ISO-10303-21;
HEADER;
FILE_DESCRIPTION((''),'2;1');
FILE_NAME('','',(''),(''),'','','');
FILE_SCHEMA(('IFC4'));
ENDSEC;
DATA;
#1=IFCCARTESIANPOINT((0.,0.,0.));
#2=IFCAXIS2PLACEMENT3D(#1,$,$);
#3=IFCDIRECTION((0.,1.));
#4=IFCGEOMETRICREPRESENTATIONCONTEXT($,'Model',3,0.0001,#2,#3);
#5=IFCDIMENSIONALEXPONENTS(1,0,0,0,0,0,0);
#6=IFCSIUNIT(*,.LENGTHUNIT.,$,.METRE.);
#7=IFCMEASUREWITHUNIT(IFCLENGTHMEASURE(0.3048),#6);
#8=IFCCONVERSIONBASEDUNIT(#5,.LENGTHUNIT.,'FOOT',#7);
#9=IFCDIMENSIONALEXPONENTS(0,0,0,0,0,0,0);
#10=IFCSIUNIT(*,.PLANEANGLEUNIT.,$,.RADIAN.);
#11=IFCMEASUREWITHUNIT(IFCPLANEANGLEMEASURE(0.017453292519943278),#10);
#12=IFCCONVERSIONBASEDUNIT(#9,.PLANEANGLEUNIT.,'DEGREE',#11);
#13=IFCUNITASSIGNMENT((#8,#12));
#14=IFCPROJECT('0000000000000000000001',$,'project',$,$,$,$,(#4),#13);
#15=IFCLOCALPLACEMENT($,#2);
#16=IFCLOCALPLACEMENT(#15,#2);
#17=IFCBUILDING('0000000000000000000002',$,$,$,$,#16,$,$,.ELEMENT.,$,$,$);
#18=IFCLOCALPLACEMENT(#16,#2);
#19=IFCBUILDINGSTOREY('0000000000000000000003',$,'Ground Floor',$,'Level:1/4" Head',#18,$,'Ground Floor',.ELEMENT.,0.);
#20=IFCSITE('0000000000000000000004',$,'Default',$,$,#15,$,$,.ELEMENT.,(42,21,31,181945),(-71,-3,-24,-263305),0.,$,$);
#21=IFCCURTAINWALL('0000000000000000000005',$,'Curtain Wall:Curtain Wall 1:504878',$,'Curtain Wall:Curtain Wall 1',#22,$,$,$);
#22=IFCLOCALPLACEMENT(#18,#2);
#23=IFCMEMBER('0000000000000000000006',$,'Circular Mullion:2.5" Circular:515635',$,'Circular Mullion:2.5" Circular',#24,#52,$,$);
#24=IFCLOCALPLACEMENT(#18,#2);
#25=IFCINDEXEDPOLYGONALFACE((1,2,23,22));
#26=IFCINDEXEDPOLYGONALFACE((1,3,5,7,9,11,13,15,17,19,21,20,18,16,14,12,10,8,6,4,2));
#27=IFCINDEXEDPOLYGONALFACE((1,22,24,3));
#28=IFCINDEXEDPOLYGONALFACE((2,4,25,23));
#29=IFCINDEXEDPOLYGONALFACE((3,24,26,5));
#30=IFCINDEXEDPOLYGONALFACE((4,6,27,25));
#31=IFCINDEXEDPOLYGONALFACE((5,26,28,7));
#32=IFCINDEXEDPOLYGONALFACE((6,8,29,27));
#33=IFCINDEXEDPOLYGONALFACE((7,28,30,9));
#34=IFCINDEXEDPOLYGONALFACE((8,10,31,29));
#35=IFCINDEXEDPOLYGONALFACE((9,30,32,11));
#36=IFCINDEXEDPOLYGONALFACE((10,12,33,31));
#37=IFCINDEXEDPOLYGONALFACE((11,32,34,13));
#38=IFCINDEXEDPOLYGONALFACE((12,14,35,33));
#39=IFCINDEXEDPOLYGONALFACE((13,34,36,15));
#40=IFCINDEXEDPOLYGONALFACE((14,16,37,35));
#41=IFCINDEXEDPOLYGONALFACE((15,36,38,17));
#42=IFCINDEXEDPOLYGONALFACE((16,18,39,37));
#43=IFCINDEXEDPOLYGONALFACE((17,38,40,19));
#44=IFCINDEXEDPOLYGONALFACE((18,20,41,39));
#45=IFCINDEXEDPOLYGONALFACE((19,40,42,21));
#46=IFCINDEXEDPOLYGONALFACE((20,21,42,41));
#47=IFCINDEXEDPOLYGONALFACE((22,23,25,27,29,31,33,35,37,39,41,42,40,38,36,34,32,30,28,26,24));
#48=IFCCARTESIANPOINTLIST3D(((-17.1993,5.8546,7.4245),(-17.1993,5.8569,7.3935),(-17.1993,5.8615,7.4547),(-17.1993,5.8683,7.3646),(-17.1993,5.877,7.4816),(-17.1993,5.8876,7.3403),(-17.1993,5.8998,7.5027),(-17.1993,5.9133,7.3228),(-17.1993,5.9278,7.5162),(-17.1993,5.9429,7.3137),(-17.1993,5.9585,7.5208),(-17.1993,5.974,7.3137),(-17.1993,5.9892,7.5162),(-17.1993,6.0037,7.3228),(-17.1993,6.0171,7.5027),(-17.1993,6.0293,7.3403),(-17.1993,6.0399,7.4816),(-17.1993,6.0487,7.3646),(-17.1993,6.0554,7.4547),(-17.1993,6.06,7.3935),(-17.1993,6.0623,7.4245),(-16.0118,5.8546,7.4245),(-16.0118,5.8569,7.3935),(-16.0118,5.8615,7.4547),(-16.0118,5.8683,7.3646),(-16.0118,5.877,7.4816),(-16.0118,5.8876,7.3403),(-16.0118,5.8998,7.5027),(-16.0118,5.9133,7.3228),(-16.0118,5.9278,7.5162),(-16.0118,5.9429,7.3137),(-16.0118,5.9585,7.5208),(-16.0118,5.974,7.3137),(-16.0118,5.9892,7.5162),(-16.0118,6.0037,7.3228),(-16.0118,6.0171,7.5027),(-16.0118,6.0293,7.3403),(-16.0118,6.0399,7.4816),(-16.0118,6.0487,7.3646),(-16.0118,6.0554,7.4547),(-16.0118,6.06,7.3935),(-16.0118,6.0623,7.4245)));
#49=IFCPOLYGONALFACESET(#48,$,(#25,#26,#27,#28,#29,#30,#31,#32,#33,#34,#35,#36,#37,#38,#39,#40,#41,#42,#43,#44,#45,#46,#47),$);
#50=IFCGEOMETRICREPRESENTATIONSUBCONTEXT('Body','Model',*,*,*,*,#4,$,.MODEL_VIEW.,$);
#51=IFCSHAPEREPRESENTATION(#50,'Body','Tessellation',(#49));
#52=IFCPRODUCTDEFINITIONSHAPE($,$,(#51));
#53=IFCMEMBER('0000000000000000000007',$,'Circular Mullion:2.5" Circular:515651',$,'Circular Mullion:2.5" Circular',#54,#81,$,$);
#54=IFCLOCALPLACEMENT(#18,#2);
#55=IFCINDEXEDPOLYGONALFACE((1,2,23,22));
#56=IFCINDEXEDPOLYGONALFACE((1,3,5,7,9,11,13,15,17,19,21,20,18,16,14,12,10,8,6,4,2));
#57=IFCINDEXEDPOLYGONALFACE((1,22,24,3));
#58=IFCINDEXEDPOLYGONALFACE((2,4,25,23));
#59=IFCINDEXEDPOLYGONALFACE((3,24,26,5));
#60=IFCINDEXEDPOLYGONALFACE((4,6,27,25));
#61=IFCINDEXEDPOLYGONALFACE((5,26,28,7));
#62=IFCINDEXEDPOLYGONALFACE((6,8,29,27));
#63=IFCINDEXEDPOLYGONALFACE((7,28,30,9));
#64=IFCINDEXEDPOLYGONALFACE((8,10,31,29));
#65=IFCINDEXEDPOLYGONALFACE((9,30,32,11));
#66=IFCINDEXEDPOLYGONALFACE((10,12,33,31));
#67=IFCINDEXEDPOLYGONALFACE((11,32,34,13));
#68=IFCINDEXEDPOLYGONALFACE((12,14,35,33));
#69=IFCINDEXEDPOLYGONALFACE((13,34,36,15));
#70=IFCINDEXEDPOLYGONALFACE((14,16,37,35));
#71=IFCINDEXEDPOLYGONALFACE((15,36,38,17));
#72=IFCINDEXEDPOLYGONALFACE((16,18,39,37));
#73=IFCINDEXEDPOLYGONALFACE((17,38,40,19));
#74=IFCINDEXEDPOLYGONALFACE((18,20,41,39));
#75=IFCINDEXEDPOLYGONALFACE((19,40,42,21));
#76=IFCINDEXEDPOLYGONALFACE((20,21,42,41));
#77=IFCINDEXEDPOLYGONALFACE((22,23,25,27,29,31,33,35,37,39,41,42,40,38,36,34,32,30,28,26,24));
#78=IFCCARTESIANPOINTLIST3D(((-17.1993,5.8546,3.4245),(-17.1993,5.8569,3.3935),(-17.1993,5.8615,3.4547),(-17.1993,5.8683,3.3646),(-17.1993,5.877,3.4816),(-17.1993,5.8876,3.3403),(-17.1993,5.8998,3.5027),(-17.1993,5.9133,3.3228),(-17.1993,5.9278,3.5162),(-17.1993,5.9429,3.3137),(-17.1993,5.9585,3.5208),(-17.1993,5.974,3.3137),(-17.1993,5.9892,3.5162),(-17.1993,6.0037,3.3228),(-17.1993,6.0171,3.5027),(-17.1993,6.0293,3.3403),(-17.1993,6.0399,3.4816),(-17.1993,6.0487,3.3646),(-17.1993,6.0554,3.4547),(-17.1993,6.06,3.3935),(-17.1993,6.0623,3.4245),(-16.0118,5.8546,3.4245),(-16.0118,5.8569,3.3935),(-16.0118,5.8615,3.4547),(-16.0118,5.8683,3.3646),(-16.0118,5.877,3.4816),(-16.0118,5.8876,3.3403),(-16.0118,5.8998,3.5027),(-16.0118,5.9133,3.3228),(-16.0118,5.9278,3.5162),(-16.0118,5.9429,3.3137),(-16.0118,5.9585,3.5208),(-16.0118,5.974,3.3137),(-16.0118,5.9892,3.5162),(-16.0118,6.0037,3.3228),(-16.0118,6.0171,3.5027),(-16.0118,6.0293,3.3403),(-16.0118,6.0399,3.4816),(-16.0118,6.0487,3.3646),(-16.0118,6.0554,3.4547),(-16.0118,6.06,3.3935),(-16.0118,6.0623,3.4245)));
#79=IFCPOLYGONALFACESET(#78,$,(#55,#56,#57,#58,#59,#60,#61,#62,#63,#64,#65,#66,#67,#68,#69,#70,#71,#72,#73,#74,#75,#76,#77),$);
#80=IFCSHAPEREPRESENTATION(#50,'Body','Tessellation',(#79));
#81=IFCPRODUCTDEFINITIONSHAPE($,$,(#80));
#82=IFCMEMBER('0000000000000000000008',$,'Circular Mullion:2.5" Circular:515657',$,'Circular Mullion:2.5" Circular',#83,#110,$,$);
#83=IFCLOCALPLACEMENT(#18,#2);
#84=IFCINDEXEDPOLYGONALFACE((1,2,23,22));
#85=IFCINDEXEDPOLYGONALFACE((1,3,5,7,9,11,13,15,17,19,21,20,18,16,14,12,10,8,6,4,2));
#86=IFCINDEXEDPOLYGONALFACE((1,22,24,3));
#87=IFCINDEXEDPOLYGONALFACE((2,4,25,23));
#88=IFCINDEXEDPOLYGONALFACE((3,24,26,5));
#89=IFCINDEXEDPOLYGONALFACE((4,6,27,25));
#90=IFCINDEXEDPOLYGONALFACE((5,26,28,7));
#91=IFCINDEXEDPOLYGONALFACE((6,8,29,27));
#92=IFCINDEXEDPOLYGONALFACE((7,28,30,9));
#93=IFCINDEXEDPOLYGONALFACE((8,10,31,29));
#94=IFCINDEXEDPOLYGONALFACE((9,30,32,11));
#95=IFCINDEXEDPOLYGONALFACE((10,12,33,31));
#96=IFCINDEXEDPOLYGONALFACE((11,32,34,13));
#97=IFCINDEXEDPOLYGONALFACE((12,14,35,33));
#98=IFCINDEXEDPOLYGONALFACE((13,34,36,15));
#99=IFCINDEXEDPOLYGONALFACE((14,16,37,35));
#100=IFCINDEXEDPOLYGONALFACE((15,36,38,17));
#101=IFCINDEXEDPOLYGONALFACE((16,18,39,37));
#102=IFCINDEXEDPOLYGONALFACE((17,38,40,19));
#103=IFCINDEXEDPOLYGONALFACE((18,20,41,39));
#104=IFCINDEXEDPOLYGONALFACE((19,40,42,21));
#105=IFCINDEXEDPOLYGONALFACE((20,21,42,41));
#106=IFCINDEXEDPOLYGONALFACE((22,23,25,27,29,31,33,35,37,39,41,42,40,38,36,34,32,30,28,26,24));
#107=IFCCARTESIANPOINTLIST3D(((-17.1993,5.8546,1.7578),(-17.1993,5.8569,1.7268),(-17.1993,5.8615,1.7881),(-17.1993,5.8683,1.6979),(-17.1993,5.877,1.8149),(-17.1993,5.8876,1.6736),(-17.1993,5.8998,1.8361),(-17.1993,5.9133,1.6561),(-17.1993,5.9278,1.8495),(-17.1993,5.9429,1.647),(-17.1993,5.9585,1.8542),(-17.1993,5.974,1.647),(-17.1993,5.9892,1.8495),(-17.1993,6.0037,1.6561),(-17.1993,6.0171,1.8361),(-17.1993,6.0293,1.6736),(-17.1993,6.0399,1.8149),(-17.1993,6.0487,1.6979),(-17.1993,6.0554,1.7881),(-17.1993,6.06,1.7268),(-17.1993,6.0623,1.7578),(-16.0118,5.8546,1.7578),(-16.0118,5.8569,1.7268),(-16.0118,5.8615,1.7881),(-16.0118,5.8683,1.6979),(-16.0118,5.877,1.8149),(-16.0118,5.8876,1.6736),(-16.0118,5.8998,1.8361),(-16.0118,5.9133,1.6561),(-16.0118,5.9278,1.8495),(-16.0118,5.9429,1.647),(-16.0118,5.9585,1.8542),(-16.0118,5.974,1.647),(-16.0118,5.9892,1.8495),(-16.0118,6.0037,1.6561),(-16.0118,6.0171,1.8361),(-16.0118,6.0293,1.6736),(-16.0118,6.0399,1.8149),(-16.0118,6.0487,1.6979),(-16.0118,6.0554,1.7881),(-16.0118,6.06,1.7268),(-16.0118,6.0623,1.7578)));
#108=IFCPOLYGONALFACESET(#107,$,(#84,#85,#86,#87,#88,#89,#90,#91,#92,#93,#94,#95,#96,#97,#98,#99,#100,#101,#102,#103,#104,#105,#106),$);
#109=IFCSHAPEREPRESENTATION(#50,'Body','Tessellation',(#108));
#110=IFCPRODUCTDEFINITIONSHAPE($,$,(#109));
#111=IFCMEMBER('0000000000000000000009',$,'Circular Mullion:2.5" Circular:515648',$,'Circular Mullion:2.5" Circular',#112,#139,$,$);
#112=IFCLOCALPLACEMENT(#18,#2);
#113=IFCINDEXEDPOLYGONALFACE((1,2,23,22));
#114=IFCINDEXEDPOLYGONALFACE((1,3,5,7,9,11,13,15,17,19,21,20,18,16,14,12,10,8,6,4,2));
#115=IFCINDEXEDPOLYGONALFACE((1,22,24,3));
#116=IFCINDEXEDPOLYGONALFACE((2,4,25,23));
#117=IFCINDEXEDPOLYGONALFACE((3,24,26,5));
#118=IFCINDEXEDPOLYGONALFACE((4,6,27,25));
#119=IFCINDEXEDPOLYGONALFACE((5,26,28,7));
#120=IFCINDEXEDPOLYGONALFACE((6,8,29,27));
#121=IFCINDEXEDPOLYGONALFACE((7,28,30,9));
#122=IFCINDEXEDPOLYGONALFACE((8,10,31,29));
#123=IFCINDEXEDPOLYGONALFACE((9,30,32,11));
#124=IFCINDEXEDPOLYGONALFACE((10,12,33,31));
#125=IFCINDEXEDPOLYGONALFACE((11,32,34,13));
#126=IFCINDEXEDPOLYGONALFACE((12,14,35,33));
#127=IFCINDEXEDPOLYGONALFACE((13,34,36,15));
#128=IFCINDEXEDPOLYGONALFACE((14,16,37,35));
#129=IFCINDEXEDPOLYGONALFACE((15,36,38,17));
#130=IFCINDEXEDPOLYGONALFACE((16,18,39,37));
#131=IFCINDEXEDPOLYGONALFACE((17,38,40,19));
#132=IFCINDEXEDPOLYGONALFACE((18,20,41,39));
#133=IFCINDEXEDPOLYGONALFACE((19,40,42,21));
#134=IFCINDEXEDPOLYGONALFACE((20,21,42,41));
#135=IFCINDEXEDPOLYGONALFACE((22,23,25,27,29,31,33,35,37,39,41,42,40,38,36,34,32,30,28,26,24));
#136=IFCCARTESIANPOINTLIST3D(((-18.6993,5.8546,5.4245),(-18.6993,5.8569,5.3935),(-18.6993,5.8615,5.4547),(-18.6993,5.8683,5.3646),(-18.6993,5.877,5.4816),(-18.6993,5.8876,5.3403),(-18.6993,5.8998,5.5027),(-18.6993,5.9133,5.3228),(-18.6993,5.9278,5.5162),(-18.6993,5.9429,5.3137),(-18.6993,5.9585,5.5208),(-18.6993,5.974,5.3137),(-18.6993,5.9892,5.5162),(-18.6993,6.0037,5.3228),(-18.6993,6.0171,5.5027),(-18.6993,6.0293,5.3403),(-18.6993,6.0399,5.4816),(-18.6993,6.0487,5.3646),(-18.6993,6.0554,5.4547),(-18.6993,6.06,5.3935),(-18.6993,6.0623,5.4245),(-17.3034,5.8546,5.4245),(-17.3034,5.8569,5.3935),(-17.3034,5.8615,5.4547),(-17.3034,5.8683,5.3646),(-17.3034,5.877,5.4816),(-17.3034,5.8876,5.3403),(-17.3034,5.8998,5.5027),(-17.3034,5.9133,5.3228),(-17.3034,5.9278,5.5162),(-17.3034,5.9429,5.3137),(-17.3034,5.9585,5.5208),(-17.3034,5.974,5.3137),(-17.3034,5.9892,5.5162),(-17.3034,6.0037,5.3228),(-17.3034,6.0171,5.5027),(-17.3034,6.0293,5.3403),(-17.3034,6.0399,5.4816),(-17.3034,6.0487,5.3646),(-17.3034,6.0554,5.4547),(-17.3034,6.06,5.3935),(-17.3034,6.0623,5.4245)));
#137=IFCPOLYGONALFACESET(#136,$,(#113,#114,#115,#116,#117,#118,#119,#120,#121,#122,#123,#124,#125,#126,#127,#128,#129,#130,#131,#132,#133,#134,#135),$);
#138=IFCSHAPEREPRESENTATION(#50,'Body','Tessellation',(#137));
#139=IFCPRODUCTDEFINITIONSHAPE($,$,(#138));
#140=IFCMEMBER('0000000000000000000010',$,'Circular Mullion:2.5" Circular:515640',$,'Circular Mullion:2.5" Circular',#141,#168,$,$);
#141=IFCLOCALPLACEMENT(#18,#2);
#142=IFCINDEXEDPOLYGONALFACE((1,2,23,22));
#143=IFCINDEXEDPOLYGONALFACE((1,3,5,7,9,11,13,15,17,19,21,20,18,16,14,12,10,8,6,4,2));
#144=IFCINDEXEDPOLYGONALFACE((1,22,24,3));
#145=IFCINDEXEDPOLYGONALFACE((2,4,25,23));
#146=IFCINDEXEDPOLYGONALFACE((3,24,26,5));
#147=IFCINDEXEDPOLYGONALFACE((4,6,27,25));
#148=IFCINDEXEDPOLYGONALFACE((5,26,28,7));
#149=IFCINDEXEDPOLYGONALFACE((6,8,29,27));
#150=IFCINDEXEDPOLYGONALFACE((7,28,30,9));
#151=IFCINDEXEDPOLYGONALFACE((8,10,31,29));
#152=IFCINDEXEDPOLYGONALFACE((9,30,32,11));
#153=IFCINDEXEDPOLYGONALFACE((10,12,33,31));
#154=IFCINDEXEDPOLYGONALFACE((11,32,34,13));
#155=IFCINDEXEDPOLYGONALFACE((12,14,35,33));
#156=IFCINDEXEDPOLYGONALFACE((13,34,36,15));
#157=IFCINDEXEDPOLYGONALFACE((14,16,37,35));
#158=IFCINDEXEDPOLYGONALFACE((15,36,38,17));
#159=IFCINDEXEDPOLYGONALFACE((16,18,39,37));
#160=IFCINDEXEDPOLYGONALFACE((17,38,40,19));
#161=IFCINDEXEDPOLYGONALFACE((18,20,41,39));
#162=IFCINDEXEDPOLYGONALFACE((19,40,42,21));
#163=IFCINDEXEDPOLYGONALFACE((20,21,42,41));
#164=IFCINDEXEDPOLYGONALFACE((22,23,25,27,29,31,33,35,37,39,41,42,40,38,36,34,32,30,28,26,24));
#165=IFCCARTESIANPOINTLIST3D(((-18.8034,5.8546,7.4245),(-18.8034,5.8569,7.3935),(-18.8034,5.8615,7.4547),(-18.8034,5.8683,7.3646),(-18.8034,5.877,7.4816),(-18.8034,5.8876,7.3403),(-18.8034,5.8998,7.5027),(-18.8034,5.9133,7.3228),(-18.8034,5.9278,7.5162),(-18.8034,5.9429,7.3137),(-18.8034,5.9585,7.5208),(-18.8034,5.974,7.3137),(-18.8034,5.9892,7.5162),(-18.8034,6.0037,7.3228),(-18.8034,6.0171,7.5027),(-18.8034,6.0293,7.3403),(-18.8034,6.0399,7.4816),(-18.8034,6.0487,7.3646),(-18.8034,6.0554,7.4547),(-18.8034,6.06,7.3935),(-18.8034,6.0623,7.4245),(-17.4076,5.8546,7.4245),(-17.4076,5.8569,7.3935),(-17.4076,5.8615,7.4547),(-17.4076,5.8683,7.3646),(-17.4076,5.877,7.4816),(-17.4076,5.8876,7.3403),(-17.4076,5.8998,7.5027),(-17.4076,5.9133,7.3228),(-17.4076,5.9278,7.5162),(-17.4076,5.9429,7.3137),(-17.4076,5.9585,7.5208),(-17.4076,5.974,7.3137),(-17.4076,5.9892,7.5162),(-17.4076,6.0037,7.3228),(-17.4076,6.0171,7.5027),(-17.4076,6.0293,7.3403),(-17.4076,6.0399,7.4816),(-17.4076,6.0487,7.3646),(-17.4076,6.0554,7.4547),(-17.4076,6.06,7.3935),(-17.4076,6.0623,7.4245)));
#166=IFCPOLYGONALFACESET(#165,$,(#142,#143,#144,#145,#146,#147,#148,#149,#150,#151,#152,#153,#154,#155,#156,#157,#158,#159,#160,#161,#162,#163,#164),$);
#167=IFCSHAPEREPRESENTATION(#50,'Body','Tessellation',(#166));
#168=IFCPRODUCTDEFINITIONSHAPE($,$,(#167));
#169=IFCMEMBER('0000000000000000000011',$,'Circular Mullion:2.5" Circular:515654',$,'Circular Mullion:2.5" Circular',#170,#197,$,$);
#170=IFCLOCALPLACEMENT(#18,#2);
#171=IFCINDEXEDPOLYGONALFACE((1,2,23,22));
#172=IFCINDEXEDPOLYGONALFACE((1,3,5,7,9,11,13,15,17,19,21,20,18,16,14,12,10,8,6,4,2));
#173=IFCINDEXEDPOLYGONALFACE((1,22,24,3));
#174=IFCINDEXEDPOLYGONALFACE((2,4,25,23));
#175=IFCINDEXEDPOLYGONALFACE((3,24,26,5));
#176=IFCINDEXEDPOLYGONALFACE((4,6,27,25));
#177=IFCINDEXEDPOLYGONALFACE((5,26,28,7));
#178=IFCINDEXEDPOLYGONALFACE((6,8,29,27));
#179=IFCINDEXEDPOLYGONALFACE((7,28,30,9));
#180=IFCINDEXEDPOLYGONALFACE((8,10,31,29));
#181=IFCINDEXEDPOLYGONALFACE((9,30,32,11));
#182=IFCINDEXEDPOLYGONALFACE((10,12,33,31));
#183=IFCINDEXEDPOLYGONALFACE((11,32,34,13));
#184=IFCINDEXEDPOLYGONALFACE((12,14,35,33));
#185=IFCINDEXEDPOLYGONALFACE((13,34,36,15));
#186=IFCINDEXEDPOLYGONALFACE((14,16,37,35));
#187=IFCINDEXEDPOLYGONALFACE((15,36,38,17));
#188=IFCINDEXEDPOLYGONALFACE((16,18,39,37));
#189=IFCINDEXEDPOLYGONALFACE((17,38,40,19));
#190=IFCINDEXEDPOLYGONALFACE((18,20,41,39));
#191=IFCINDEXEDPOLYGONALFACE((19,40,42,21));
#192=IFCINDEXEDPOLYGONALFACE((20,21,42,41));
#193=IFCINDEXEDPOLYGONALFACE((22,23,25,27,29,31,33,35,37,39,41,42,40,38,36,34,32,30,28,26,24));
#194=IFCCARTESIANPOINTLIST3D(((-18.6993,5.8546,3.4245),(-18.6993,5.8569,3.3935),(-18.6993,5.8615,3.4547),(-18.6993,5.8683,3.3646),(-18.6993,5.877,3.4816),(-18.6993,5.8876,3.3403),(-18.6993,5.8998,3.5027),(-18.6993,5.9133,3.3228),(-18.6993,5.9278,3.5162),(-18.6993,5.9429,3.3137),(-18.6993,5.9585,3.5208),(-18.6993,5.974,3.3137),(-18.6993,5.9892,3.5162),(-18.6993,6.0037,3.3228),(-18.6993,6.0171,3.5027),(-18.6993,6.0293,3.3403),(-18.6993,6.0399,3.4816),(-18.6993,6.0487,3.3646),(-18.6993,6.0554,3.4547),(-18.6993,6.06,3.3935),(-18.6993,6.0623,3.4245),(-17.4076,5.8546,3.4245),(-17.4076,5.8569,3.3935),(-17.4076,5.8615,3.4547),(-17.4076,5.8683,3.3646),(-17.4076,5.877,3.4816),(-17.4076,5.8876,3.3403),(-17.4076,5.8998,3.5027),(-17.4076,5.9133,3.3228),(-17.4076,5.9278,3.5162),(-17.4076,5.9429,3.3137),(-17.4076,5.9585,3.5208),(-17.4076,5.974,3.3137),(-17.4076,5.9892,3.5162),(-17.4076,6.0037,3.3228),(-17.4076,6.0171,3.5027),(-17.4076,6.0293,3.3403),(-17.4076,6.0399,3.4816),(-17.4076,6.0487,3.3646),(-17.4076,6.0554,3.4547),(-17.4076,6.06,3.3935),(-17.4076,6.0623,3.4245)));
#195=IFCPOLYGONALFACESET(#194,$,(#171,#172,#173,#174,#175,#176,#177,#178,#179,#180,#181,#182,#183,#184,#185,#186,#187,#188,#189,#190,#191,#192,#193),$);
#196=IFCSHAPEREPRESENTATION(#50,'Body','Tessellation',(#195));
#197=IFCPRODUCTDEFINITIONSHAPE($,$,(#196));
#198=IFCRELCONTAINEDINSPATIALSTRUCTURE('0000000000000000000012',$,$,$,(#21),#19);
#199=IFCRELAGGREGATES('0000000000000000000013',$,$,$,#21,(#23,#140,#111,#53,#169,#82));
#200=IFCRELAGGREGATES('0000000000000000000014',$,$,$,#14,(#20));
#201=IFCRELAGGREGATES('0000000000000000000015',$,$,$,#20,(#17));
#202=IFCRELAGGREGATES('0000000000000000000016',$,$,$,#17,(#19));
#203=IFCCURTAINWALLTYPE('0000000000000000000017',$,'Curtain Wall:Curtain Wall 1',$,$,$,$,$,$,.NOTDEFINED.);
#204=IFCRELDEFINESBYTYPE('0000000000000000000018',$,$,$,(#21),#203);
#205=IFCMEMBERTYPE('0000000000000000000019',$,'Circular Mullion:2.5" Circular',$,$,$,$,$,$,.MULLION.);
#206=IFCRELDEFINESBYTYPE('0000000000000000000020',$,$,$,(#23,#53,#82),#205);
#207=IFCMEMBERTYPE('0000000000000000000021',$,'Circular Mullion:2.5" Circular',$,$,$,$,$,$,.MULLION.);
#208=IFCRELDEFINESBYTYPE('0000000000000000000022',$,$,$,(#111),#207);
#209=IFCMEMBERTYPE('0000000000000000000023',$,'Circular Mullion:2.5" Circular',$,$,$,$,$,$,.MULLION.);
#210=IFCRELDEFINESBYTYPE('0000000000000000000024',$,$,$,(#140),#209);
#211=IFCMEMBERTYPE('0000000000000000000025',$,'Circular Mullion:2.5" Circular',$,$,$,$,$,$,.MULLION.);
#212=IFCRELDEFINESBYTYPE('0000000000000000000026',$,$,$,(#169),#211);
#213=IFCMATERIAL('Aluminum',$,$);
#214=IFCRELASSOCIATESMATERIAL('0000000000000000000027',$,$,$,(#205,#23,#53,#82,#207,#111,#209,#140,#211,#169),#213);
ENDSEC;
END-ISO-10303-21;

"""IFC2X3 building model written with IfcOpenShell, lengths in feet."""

from ifc_helpers import new_model, entity, si_unit, converted_unit, direction, frame, frame_2d, origin, place, context, subcontext, project, spatial, circle, extrude, source, transform, mapped, material, type_object, type_shapes, element, aggregate, save


model = new_model("IFC2X3")

# Units and contexts
model_context = context("Model", 3, precision=0.0001, world=origin(), true_north=direction((0.0, 1.0)))
body_context = subcontext(model_context, "Body", "Model", "MODEL_VIEW")
ifc_project = project(units=[converted_unit("LENGTHUNIT", "FOOT", entity("IfcLengthMeasure", 0.3048), si_unit("LENGTHUNIT", "METRE"), dimensions=[1, 0, 0, 0, 0, 0, 0]), converted_unit("PLANEANGLEUNIT", "DEGREE", entity("IfcPlaneAngleMeasure", 0.017453292519943278), si_unit("PLANEANGLEUNIT", "RADIAN"), dimensions=[0, 0, 0, 0, 0, 0, 0])], contexts=[model_context])

# Site, building, storey
site_placement = place(None, origin())
site = spatial("IfcSite", under=ifc_project, at=site_placement, Name="Default", CompositionType="ELEMENT", RefLatitude=(42, 21, 31, 181945), RefLongitude=(-71, -3, -24, -263305), RefElevation=0.0)
building_placement = place(site_placement, origin())
building = spatial("IfcBuilding", under=site, at=building_placement, CompositionType="ELEMENT")
storey_placement = place(building_placement, origin())
storey = spatial("IfcBuildingStorey", under=building, at=storey_placement, Name="Ground Floor", ObjectType="Level:1/4\" Head", LongName="Ground Floor", CompositionType="ELEMENT", Elevation=0.0)

# Curtain wall, members
curtain_wall_type = type_object("IfcCurtainWallType", Name="Curtain Wall:Curtain Wall 1", PredefinedType="NOTDEFINED")
curtain_wall_placement = place(storey_placement, origin())
curtain_wall = element("IfcCurtainWall", 1, at=curtain_wall_placement, inside=storey, type_object=curtain_wall_type, Name="Curtain Wall:Curtain Wall 1:504878", ObjectType="Curtain Wall:Curtain Wall 1")
ifc_material_1 = material(Name="Aluminum")
member_type_1 = type_object("IfcMemberType", Name="Circular Mullion:2.5\" Circular", PredefinedType="MULLION", material=ifc_material_1)
shared_shape_1 = source(origin(), body_context, "Body", "SweptSolid", [
    extrude(circle(Radius=0.1042, at=frame_2d((0.0, 0.0), x_axis=(1.0, 0.0))), frame((0.0, 0.0, -1.1875)), (0.0, 0.0, 1.0), 1.1875),
])
type_shapes(member_type_1, [shared_shape_1])
member_1_placement = place(curtain_wall_placement, frame((-17.1993, 5.9585, 7.4167), z_axis=(-1.0, 0.0, 0.0), x_axis=(0.0, 0.0, 1.0)))
member_1 = element("IfcMember", 2, at=member_1_placement, type_object=member_type_1, material=ifc_material_1, Name="Circular Mullion:2.5\" Circular:515635", ObjectType="Circular Mullion:2.5\" Circular", context=body_context, shape_type="MappedRepresentation", body=[
    mapped(shared_shape_1, transform((0.0, 0.0, 0.0), scale=1.0)),
])
member_2_placement = place(curtain_wall_placement, frame((-17.1993, 5.9585, 3.4167), z_axis=(-1.0, 0.0, 0.0), x_axis=(0.0, 0.0, 1.0)))
member_2 = element("IfcMember", 3, at=member_2_placement, type_object=member_type_1, material=ifc_material_1, Name="Circular Mullion:2.5\" Circular:515651", ObjectType="Circular Mullion:2.5\" Circular", context=body_context, shape_type="MappedRepresentation", body=[
    mapped(shared_shape_1, transform((0.0, 0.0, 0.0), scale=1.0)),
])
member_3_placement = place(curtain_wall_placement, frame((-17.1993, 5.9585, 1.75), z_axis=(-1.0, 0.0, 0.0), x_axis=(0.0, 0.0, 1.0)))
member_3 = element("IfcMember", 4, at=member_3_placement, type_object=member_type_1, material=ifc_material_1, Name="Circular Mullion:2.5\" Circular:515657", ObjectType="Circular Mullion:2.5\" Circular", context=body_context, shape_type="MappedRepresentation", body=[
    mapped(shared_shape_1, transform((0.0, 0.0, 0.0), scale=1.0)),
])
member_type_2 = type_object("IfcMemberType", Name="Circular Mullion:2.5\" Circular", PredefinedType="MULLION", material=ifc_material_1)
shared_shape_2 = source(origin(), body_context, "Body", "SweptSolid", [
    extrude(circle(Radius=0.1042, at=frame_2d((0.0, 0.0), x_axis=(1.0, 0.0))), frame((0.0, 0.0, -1.3958)), (0.0, 0.0, 1.0), 1.3958),
])
type_shapes(member_type_2, [shared_shape_2])
member_4_placement = place(curtain_wall_placement, frame((-18.6993, 5.9585, 5.4167), z_axis=(-1.0, 0.0, 0.0), x_axis=(0.0, 0.0, 1.0)))
member_4 = element("IfcMember", 5, at=member_4_placement, type_object=member_type_2, material=ifc_material_1, Name="Circular Mullion:2.5\" Circular:515648", ObjectType="Circular Mullion:2.5\" Circular", context=body_context, shape_type="MappedRepresentation", body=[
    mapped(shared_shape_2, transform((0.0, 0.0, 0.0), scale=1.0)),
])
member_type_3 = type_object("IfcMemberType", Name="Circular Mullion:2.5\" Circular", PredefinedType="MULLION", material=ifc_material_1)
shared_shape_3 = source(origin(), body_context, "Body", "SweptSolid", [
    extrude(circle(Radius=0.1042, at=frame_2d((0.0, 0.0), x_axis=(1.0, 0.0))), frame((0.0, 0.0, -1.3958)), (0.0, 0.0, 1.0), 1.3958),
])
type_shapes(member_type_3, [shared_shape_3])
member_5_placement = place(curtain_wall_placement, frame((-18.8034, 5.9585, 7.4167), z_axis=(-1.0, 0.0, 0.0), x_axis=(0.0, 0.0, 1.0)))
member_5 = element("IfcMember", 6, at=member_5_placement, type_object=member_type_3, material=ifc_material_1, Name="Circular Mullion:2.5\" Circular:515640", ObjectType="Circular Mullion:2.5\" Circular", context=body_context, shape_type="MappedRepresentation", body=[
    mapped(shared_shape_3, transform((0.0, 0.0, 0.0), scale=1.0)),
])
member_type_4 = type_object("IfcMemberType", Name="Circular Mullion:2.5\" Circular", PredefinedType="MULLION", material=ifc_material_1)
shared_shape_4 = source(origin(), body_context, "Body", "SweptSolid", [
    extrude(circle(Radius=0.1042, at=frame_2d((0.0, 0.0), x_axis=(1.0, 0.0))), frame((0.0, 0.0, -1.2917)), (0.0, 0.0, 1.0), 1.2917),
])
type_shapes(member_type_4, [shared_shape_4])
member_6_placement = place(curtain_wall_placement, frame((-18.6993, 5.9585, 3.4167), z_axis=(-1.0, 0.0, 0.0), x_axis=(0.0, 0.0, 1.0)))
member_6 = element("IfcMember", 7, at=member_6_placement, type_object=member_type_4, material=ifc_material_1, Name="Circular Mullion:2.5\" Circular:515654", ObjectType="Circular Mullion:2.5\" Circular", context=body_context, shape_type="MappedRepresentation", body=[
    mapped(shared_shape_4, transform((0.0, 0.0, 0.0), scale=1.0)),
])
aggregate(curtain_wall, [member_1, member_5, member_4, member_2, member_6, member_3])

save(model, "model.ifc")
